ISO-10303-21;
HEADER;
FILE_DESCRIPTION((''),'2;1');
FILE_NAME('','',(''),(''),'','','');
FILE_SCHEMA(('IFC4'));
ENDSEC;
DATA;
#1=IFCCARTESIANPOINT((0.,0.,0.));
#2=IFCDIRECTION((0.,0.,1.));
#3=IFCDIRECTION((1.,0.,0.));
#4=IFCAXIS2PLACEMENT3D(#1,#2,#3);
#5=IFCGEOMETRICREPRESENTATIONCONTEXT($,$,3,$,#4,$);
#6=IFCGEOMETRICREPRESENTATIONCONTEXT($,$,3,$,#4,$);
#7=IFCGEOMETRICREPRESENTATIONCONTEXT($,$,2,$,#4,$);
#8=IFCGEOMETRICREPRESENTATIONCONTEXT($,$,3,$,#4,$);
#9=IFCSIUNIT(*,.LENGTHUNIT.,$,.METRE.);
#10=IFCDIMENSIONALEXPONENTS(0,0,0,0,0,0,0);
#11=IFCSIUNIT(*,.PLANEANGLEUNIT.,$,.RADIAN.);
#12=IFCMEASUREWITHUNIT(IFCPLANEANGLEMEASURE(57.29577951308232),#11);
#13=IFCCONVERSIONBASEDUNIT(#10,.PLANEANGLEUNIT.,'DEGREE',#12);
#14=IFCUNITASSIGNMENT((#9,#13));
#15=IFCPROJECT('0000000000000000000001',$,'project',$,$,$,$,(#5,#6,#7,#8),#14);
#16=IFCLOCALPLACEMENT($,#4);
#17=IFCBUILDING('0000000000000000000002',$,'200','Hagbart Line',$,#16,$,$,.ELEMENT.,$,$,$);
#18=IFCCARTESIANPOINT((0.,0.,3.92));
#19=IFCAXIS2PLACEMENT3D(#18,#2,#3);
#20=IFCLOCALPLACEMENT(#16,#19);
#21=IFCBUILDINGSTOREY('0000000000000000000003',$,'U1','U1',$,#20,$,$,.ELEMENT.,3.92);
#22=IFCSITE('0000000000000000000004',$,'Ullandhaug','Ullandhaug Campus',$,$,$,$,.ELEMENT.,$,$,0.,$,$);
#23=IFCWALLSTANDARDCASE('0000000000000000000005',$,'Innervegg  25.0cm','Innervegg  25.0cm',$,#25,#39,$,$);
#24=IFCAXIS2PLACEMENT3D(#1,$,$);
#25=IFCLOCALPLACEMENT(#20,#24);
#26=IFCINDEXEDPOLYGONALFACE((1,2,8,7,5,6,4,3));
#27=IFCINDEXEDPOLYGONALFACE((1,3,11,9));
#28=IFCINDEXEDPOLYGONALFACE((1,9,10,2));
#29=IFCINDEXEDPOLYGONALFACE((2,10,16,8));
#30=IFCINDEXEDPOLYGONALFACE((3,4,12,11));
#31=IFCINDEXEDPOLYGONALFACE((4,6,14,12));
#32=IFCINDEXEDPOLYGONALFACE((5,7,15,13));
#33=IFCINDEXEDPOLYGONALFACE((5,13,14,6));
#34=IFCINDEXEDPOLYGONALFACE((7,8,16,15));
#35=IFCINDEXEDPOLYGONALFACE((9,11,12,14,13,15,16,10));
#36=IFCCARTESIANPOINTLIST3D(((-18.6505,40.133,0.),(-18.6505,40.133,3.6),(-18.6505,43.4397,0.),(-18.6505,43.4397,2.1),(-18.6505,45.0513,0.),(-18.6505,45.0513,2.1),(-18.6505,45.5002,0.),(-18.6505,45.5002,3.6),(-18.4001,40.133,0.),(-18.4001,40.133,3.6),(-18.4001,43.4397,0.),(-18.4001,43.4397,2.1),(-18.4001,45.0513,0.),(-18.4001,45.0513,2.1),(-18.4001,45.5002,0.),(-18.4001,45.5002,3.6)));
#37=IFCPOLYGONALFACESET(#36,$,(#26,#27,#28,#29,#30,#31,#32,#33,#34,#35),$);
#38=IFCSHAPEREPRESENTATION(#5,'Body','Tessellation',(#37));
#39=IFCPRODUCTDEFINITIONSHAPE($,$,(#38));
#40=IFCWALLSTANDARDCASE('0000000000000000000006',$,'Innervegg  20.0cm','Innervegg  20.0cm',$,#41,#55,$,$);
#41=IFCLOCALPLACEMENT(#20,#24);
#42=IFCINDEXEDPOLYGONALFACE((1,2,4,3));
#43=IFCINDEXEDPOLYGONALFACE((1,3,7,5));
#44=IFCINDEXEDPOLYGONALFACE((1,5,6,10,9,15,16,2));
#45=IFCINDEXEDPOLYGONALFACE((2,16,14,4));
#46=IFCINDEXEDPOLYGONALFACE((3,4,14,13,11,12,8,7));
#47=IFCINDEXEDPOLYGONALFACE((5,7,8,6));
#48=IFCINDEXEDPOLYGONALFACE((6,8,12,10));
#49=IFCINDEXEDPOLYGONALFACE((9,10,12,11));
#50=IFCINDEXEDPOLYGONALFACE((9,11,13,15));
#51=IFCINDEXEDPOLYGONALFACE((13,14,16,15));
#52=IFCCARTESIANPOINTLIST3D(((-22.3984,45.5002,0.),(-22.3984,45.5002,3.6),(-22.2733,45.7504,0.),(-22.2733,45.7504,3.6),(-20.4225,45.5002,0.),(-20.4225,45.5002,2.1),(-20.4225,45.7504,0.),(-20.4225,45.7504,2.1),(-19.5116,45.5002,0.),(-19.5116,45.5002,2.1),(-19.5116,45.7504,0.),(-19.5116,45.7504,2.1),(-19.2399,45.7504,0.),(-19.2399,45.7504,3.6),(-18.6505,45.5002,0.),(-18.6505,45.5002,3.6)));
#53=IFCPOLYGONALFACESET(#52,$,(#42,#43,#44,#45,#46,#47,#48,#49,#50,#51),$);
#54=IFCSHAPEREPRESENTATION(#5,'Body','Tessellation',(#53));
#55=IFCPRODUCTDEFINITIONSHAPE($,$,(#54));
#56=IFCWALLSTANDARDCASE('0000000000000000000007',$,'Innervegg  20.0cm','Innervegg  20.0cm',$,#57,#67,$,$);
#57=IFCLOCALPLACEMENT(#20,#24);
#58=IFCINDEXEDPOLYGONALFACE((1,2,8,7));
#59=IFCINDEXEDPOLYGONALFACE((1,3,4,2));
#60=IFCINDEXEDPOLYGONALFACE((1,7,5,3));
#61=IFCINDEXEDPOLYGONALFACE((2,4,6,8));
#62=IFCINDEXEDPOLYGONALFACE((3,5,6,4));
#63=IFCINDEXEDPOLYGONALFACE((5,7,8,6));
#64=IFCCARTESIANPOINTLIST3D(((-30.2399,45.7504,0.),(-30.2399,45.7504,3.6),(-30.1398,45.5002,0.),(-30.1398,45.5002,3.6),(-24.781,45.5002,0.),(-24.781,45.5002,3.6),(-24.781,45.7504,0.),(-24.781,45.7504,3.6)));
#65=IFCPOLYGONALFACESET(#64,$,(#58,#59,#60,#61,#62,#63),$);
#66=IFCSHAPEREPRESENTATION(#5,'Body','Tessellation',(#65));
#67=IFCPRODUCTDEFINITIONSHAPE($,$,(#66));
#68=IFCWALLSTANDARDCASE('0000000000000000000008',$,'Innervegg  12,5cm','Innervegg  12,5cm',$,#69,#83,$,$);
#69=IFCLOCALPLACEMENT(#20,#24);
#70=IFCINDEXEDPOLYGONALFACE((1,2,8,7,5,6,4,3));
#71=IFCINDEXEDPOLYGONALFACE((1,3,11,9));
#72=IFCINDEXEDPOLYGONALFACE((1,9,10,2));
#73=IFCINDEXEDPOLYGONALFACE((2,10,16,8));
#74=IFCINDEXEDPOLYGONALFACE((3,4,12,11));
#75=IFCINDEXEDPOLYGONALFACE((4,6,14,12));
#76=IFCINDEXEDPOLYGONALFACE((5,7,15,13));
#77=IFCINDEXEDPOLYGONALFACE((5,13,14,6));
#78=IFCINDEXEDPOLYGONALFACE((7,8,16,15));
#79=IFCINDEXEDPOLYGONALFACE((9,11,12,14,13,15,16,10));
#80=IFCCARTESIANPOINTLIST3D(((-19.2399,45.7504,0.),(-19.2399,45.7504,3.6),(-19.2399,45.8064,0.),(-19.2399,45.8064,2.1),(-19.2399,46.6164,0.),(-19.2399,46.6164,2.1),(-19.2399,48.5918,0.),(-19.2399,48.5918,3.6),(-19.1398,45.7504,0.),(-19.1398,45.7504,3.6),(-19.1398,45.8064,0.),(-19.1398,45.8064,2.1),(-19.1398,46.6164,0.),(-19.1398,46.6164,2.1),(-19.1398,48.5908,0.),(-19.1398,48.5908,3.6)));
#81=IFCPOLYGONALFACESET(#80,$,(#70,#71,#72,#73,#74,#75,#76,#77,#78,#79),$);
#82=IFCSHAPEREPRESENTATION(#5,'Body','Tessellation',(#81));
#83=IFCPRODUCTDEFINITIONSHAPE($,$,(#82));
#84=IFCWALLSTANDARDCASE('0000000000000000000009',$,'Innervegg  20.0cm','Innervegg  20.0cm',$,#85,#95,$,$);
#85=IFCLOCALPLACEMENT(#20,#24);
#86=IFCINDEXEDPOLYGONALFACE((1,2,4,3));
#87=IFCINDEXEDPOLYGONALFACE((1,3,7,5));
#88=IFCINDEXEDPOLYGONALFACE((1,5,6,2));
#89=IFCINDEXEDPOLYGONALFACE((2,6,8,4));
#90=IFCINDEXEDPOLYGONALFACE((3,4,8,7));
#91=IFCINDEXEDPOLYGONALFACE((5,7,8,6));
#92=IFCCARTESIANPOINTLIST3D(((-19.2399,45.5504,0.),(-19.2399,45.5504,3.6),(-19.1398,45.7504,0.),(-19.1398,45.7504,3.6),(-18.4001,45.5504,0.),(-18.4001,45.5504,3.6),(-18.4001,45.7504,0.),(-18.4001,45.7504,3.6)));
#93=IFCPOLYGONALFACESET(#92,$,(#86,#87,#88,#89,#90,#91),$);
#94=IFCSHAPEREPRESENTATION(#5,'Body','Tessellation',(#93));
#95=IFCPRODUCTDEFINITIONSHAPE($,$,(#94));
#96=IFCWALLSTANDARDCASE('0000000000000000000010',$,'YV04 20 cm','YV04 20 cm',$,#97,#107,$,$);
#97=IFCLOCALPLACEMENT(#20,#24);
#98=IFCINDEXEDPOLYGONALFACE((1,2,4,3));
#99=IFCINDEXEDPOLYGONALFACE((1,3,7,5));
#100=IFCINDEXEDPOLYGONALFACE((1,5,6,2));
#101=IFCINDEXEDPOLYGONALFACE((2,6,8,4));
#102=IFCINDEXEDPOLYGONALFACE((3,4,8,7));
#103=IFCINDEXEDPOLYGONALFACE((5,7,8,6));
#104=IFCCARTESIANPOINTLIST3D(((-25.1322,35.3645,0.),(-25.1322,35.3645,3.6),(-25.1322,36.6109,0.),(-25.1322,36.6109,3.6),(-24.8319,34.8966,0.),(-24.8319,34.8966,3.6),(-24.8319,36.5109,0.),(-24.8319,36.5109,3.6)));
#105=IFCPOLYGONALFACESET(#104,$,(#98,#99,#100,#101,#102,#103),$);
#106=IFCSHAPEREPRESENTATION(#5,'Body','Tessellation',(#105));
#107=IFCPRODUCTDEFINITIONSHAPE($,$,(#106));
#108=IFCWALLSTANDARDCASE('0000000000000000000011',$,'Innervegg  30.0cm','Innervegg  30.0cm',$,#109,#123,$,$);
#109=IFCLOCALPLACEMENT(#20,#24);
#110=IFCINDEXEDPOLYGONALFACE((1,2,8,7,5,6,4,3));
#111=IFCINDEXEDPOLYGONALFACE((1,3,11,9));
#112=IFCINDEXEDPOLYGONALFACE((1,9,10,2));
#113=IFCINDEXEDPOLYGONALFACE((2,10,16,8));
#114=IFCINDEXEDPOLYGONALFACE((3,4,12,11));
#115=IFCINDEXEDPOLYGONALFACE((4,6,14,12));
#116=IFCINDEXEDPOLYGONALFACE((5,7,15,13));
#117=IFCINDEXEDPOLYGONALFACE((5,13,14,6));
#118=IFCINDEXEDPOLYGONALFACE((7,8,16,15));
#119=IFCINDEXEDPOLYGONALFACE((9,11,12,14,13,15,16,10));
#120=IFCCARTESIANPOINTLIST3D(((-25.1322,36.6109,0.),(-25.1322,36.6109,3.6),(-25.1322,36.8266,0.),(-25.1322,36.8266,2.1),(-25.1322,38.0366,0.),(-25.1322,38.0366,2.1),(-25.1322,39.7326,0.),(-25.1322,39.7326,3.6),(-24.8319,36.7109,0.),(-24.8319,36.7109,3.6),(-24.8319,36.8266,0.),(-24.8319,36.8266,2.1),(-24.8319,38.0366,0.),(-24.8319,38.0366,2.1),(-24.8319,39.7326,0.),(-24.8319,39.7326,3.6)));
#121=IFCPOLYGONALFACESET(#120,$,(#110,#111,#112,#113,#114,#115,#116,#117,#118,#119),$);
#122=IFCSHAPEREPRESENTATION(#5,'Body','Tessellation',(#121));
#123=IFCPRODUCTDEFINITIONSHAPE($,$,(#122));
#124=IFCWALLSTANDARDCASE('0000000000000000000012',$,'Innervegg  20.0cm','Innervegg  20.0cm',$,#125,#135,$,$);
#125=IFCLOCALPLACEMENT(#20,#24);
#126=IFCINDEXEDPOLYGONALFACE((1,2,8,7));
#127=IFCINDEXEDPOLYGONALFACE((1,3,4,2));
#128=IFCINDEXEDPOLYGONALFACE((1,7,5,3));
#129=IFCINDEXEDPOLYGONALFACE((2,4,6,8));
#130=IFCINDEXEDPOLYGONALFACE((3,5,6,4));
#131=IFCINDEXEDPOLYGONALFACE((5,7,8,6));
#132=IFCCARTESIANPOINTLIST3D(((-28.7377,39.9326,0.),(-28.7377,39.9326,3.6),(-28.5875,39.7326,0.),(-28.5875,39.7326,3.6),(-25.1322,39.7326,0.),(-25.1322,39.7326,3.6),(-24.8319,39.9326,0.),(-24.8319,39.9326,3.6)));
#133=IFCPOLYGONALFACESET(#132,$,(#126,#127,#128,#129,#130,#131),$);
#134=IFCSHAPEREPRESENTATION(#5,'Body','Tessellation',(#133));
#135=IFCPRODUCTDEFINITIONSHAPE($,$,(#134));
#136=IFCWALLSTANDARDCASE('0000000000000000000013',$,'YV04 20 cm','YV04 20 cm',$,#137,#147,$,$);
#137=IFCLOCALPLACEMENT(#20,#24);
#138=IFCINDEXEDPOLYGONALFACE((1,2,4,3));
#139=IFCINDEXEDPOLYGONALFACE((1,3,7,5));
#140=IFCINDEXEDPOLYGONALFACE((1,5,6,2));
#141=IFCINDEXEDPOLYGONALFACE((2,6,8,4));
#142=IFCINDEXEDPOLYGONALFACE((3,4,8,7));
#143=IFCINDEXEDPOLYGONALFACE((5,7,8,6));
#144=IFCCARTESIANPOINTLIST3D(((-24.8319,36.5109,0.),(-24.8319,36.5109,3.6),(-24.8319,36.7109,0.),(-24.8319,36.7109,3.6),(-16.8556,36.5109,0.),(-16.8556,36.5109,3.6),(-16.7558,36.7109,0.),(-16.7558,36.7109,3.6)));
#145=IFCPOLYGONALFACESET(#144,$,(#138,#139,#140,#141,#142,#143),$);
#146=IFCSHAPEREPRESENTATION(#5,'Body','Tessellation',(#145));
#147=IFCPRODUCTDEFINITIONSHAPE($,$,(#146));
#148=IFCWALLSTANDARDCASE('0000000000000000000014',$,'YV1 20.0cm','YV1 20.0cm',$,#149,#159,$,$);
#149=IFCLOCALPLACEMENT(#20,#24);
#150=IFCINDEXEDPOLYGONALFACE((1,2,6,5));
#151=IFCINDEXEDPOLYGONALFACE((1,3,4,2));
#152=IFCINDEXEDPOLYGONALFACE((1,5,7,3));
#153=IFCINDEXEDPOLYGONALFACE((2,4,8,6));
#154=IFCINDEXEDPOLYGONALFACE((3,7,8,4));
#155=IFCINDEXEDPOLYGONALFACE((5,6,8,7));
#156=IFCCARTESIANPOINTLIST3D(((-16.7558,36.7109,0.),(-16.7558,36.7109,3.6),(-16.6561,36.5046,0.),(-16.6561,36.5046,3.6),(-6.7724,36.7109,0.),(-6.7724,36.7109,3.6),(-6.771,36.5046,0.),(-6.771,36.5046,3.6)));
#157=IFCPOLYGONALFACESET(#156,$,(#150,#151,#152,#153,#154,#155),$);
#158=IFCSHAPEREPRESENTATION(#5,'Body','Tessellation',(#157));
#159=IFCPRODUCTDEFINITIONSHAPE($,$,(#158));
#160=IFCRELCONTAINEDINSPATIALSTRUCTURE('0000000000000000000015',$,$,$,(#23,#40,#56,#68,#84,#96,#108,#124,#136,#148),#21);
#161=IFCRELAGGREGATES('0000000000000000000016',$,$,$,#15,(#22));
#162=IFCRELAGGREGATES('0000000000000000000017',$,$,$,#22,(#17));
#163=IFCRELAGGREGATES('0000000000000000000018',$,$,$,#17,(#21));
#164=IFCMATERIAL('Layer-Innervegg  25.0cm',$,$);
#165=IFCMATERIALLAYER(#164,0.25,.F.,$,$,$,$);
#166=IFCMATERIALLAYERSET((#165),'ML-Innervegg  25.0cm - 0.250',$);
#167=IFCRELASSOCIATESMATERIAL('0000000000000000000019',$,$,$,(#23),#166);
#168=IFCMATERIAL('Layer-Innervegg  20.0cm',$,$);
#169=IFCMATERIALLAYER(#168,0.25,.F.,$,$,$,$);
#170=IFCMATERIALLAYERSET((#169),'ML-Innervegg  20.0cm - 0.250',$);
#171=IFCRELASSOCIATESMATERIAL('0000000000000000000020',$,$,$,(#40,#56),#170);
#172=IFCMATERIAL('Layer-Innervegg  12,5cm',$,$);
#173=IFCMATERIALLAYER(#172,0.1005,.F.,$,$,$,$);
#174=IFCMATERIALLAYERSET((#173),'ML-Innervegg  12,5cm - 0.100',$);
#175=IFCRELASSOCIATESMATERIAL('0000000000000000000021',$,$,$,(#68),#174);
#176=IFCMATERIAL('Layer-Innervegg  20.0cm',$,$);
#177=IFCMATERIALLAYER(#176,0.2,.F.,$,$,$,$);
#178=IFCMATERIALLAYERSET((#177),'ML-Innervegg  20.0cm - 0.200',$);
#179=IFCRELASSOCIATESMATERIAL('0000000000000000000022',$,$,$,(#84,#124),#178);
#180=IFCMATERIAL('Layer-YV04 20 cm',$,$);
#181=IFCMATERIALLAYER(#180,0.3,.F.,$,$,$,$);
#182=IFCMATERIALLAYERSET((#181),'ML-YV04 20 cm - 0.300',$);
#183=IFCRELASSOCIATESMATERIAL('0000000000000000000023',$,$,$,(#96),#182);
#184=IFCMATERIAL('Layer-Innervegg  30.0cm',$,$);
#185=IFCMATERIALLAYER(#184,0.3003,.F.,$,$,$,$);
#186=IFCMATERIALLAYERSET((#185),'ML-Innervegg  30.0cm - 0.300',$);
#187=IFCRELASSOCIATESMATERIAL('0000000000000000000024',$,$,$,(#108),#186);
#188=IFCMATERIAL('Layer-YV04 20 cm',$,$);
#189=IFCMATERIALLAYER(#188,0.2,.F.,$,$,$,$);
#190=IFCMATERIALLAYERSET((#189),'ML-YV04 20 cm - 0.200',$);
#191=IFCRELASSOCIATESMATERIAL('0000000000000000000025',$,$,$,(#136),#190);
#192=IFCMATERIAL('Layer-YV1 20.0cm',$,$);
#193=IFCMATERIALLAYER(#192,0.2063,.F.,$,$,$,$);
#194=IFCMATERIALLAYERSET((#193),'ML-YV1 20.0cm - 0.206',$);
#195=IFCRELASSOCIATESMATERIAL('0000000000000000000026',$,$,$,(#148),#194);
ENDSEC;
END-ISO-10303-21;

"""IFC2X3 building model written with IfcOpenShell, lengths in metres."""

from ifc_helpers import new_model, entity, si_unit, converted_unit, frame, origin_with_axes, place, context, project, spatial, polyline, outline, extrude, material, layer, layer_set, layer_usage, element, save


model = new_model("IFC2X3")

# Units and contexts
context_of_model_1 = context(None, 3, world=origin_with_axes())
context_of_model_2 = context(None, 3, world=origin_with_axes())
context_of_model_3 = context(None, 2, world=origin_with_axes())
context_of_model_4 = context(None, 3, world=origin_with_axes())
ifc_project = project(units=[si_unit("LENGTHUNIT", "METRE"), converted_unit("PLANEANGLEUNIT", "DEGREE", entity("IfcPlaneAngleMeasure", 57.29577951308232), si_unit("PLANEANGLEUNIT", "RADIAN"), dimensions=[0, 0, 0, 0, 0, 0, 0])], contexts=[context_of_model_1, context_of_model_2, context_of_model_3, context_of_model_4])

# Site, building, storey
site = spatial("IfcSite", under=ifc_project, Name="Ullandhaug", Description="Ullandhaug Campus", CompositionType="ELEMENT", RefElevation=0.0)
building_placement = place(None, origin_with_axes())
building = spatial("IfcBuilding", under=site, at=building_placement, Name="200", Description="Hagbart Line", CompositionType="ELEMENT")
storey_placement = place(building_placement, frame((0.0, 0.0, 3.92), z_axis=(0.0, 0.0, 1.0), x_axis=(1.0, 0.0, 0.0)))
storey = spatial("IfcBuildingStorey", under=building, at=storey_placement, Name="U1", Description="U1", CompositionType="ELEMENT", Elevation=3.92)

# Shared definitions
ifc_material_1 = material(Name="Layer-Innervegg  20.0cm")
ifc_layer_1 = layer(ifc_material_1, 0.25, ventilated=False)
ifc_layer_set_1 = layer_set([ifc_layer_1], Name="ML-Innervegg  20.0cm - 0.250")
ifc_layer_usage_1 = layer_usage(ifc_layer_set_1, "AXIS2", "POSITIVE", 0.0)

# Shared definitions
ifc_material_2 = material(Name="Layer-Innervegg  20.0cm")
ifc_layer_2 = layer(ifc_material_2, 0.2, ventilated=False)
ifc_layer_set_2 = layer_set([ifc_layer_2], Name="ML-Innervegg  20.0cm - 0.200")
ifc_layer_usage_2 = layer_usage(ifc_layer_set_2, "AXIS2", "POSITIVE", 0.0)

# Walls, openings
ifc_material_3 = material(Name="Layer-Innervegg  25.0cm")
ifc_layer_3 = layer(ifc_material_3, 0.25, ventilated=False)
ifc_layer_set_3 = layer_set([ifc_layer_3], Name="ML-Innervegg  25.0cm - 0.250")
ifc_layer_usage_3 = layer_usage(ifc_layer_set_3, "AXIS2", "POSITIVE", 0.0)
wall_1_placement = place(storey_placement, frame((-18.6505, 45.5002, 0.0), z_axis=(0.0, 0.0, 1.0), x_axis=(0.0, -1.0, 0.0)))
wall_1 = element("IfcWallStandardCase", 1, at=wall_1_placement, inside=storey, material=ifc_layer_usage_3, Name="Innervegg  25.0cm", Description="Innervegg  25.0cm", context=context_of_model_1, shape_type="SweptSolid", body=[
    extrude(outline(polyline([(0.0, 0.0), (5.3672, 0.0), (5.3672, 0.2505), (0.0, 0.2505), (0.0, 0.0)])), frame((0.0, 0.0, 0.0), z_axis=(0.0, 0.0, 1.0), x_axis=(1.0, 0.0, 0.0)), (0.0, 0.0, 1.0), 3.6),
])
opening_1_placement = place(wall_1_placement, frame((0.4488, 0.2505, 0.0), z_axis=(0.0, 0.0, 1.0), x_axis=(1.0, 0.0, 0.0)))
element("IfcOpeningElement", 2, at=opening_1_placement, cuts=wall_1, context=context_of_model_1, shape_type="SweptSolid", body=[
    extrude(outline(polyline([(0.0, 0.0), (2.1, 0.0), (2.1, 1.6116), (0.0, 1.6116), (0.0, 0.0)])), frame((0.0, 0.0, 0.0), z_axis=(0.0, 1.0, 0.0), x_axis=(0.0, 0.0, 1.0)), (0.0, 0.0, -1.0), 0.2505),
])
wall_2_placement = place(storey_placement, frame((-19.2399, 45.7504, 0.0), z_axis=(0.0, 0.0, 1.0), x_axis=(-1.0, 0.0, 0.0)))
wall_2 = element("IfcWallStandardCase", 3, at=wall_2_placement, inside=storey, material=ifc_layer_usage_1, Name="Innervegg  20.0cm", Description="Innervegg  20.0cm", context=context_of_model_1, shape_type="SweptSolid", body=[
    extrude(outline(polyline([(0.0, 0.0), (3.0334, 0.0), (3.1585, 0.2502), (-0.5894, 0.2502), (0.0, 0.0)])), frame((0.0, 0.0, 0.0), z_axis=(0.0, 0.0, 1.0), x_axis=(1.0, 0.0, 0.0)), (0.0, 0.0, 1.0), 3.6),
])
opening_2_placement = place(wall_2_placement, frame((0.2717, 0.2502, 0.0), z_axis=(0.0, 0.0, 1.0), x_axis=(1.0, 0.0, 0.0)))
element("IfcOpeningElement", 4, at=opening_2_placement, cuts=wall_2, context=context_of_model_1, shape_type="SweptSolid", body=[
    extrude(outline(polyline([(0.0, 0.0), (2.1, 0.0), (2.1, 0.9109), (0.0, 0.9109), (0.0, 0.0)])), frame((0.0, 0.0, 0.0), z_axis=(0.0, 1.0, 0.0), x_axis=(0.0, 0.0, 1.0)), (0.0, 0.0, -1.0), 0.2502),
])

# Wall
wall_3_placement = place(storey_placement, frame((-24.781, 45.7504, 0.0), z_axis=(0.0, 0.0, 1.0), x_axis=(-1.0, 0.0, 0.0)))
element("IfcWallStandardCase", 5, at=wall_3_placement, inside=storey, material=ifc_layer_usage_1, Name="Innervegg  20.0cm", Description="Innervegg  20.0cm", context=context_of_model_1, shape_type="SweptSolid", body=[
    extrude(outline(polyline([(0.0, 0.0), (5.4589, 0.0), (5.3588, 0.2502), (0.0, 0.2502), (0.0, 0.0)])), frame((0.0, 0.0, 0.0), z_axis=(0.0, 0.0, 1.0), x_axis=(1.0, 0.0, 0.0)), (0.0, 0.0, 1.0), 3.6),
])

# Wall, opening
ifc_material_4 = material(Name="Layer-Innervegg  12,5cm")
ifc_layer_4 = layer(ifc_material_4, 0.1005, ventilated=False)
ifc_layer_set_4 = layer_set([ifc_layer_4], Name="ML-Innervegg  12,5cm - 0.100")
ifc_layer_usage_4 = layer_usage(ifc_layer_set_4, "AXIS2", "POSITIVE", 0.0)
wall_4_placement = place(storey_placement, frame((-19.1398, 45.7504, 0.0), z_axis=(0.0, 0.0, 1.0), x_axis=(0.0, 1.0, 0.0)))
wall_4 = element("IfcWallStandardCase", 6, at=wall_4_placement, inside=storey, material=ifc_layer_usage_4, Name="Innervegg  12,5cm", Description="Innervegg  12,5cm", context=context_of_model_1, shape_type="SweptSolid", body=[
    extrude(outline(polyline([(0.0, 0.0), (2.8404, 0.0), (2.8414, 0.1001), (0.0, 0.1001), (0.0, 0.0)])), frame((0.0, 0.0, 0.0), z_axis=(0.0, 0.0, 1.0), x_axis=(1.0, 0.0, 0.0)), (0.0, 0.0, 1.0), 3.6),
])
opening_3_placement = place(wall_4_placement, frame((0.056, 0.1001, 0.0), z_axis=(0.0, 0.0, 1.0), x_axis=(1.0, 0.0, 0.0)))
element("IfcOpeningElement", 7, at=opening_3_placement, cuts=wall_4, context=context_of_model_1, shape_type="SweptSolid", body=[
    extrude(outline(polyline([(0.0, 0.0), (2.1, 0.0), (2.1, 0.81), (0.0, 0.81), (0.0, 0.0)])), frame((0.0, 0.0, 0.0), z_axis=(0.0, 1.0, 0.0), x_axis=(0.0, 0.0, 1.0)), (0.0, 0.0, -1.0), 0.1001),
])

# Walls
wall_5_placement = place(storey_placement, frame((-19.2399, 45.5504, 0.0), z_axis=(0.0, 0.0, 1.0), x_axis=(1.0, 0.0, 0.0)))
element("IfcWallStandardCase", 8, at=wall_5_placement, inside=storey, material=ifc_layer_usage_2, Name="Innervegg  20.0cm", Description="Innervegg  20.0cm", context=context_of_model_1, shape_type="SweptSolid", body=[
    extrude(outline(polyline([(0.0, 0.0), (0.8398, 0.0), (0.8398, 0.2), (0.1001, 0.2), (0.0, 0.0)])), origin_with_axes(), (0.0, 0.0, 1.0), 3.6),
])
ifc_material_5 = material(Name="Layer-YV04 20 cm")
ifc_layer_5 = layer(ifc_material_5, 0.3, ventilated=False)
ifc_layer_set_5 = layer_set([ifc_layer_5], Name="ML-YV04 20 cm - 0.300")
ifc_layer_usage_5 = layer_usage(ifc_layer_set_5, "AXIS2", "POSITIVE", 0.0)
wall_6_placement = place(storey_placement, frame((-24.8319, 34.8966, 0.0), z_axis=(0.0, 0.0, 1.0), x_axis=(0.0, 1.0, 0.0)))
element("IfcWallStandardCase", 9, at=wall_6_placement, inside=storey, material=ifc_layer_usage_5, Name="YV04 20 cm", Description="YV04 20 cm", context=context_of_model_1, shape_type="SweptSolid", body=[
    extrude(outline(polyline([(0.0, 0.0), (1.6143, 0.0), (1.7143, 0.3003), (0.4679, 0.3003), (0.0, 0.0)])), frame((0.0, 0.0, 0.0), z_axis=(0.0, 0.0, 1.0), x_axis=(1.0, 0.0, 0.0)), (0.0, 0.0, 1.0), 3.6),
])

# Wall, opening
ifc_material_6 = material(Name="Layer-Innervegg  30.0cm")
ifc_layer_6 = layer(ifc_material_6, 0.3003, ventilated=False)
ifc_layer_set_6 = layer_set([ifc_layer_6], Name="ML-Innervegg  30.0cm - 0.300")
ifc_layer_usage_6 = layer_usage(ifc_layer_set_6, "AXIS2", "POSITIVE", 0.0)
wall_7_placement = place(storey_placement, frame((-24.8319, 36.7109, 0.0), z_axis=(0.0, 0.0, 1.0), x_axis=(0.0, 1.0, 0.0)))
wall_7 = element("IfcWallStandardCase", 10, at=wall_7_placement, inside=storey, material=ifc_layer_usage_6, Name="Innervegg  30.0cm", Description="Innervegg  30.0cm", context=context_of_model_1, shape_type="SweptSolid", body=[
    extrude(outline(polyline([(0.0, 0.0), (3.0216, 0.0), (3.0216, 0.3003), (-0.1, 0.3003), (0.0, 0.0)])), frame((0.0, 0.0, 0.0), z_axis=(0.0, 0.0, 1.0), x_axis=(1.0, 0.0, 0.0)), (0.0, 0.0, 1.0), 3.6),
])
opening_4_placement = place(wall_7_placement, frame((0.1156, 0.3003, 0.0), z_axis=(0.0, 0.0, 1.0), x_axis=(1.0, 0.0, 0.0)))
element("IfcOpeningElement", 11, at=opening_4_placement, cuts=wall_7, context=context_of_model_1, shape_type="SweptSolid", body=[
    extrude(outline(polyline([(0.0, 0.0), (2.1, 0.0), (2.1, 1.21), (0.0, 1.21), (0.0, 0.0)])), frame((0.0, 0.0, 0.0), z_axis=(0.0, 1.0, 0.0), x_axis=(0.0, 0.0, 1.0)), (0.0, 0.0, -1.0), 0.3003),
])

# Walls
wall_8_placement = place(storey_placement, frame((-24.8319, 39.9326, 0.0), z_axis=(0.0, 0.0, 1.0), x_axis=(-1.0, 0.0, 0.0)))
element("IfcWallStandardCase", 12, at=wall_8_placement, inside=storey, material=ifc_layer_usage_2, Name="Innervegg  20.0cm", Description="Innervegg  20.0cm", context=context_of_model_1, shape_type="SweptSolid", body=[
    extrude(outline(polyline([(0.0, 0.0), (3.9058, 0.0), (3.7556, 0.2), (0.3003, 0.2), (0.0, 0.0)])), frame((0.0, 0.0, 0.0), z_axis=(0.0, 0.0, 1.0), x_axis=(1.0, 0.0, 0.0)), (0.0, 0.0, 1.0), 3.6),
])
ifc_material_7 = material(Name="Layer-YV04 20 cm")
ifc_layer_7 = layer(ifc_material_7, 0.2, ventilated=False)
ifc_layer_set_7 = layer_set([ifc_layer_7], Name="ML-YV04 20 cm - 0.200")
ifc_layer_usage_7 = layer_usage(ifc_layer_set_7, "AXIS2", "POSITIVE", 0.0)
wall_9_placement = place(storey_placement, frame((-24.8319, 36.5109, 0.0), z_axis=(0.0, 0.0, 1.0), x_axis=(1.0, 0.0, 0.0)))
element("IfcWallStandardCase", 13, at=wall_9_placement, inside=storey, material=ifc_layer_usage_7, Name="YV04 20 cm", Description="YV04 20 cm", context=context_of_model_1, shape_type="SweptSolid", body=[
    extrude(outline(polyline([(0.0, 0.0), (7.9763, 0.0), (8.0761, 0.2), (0.0, 0.2), (0.0, 0.0)])), origin_with_axes(), (0.0, 0.0, 1.0), 3.6),
])
ifc_material_8 = material(Name="Layer-YV1 20.0cm")
ifc_layer_8 = layer(ifc_material_8, 0.2063, ventilated=False)
ifc_layer_set_8 = layer_set([ifc_layer_8], Name="ML-YV1 20.0cm - 0.206")
ifc_layer_usage_8 = layer_usage(ifc_layer_set_8, "AXIS2", "POSITIVE", 0.0)
wall_10_placement = place(storey_placement, frame((-16.6561, 36.5046, 0.0), z_axis=(0.0, 0.0, 1.0), x_axis=(1.0, 0.0, 0.0)))
element("IfcWallStandardCase", 14, at=wall_10_placement, inside=storey, material=ifc_layer_usage_8, Name="YV1 20.0cm", Description="YV1 20.0cm", context=context_of_model_1, shape_type="SweptSolid", body=[
    extrude(outline(polyline([(0.0, 0.0), (9.8851, 0.0), (9.8837, 0.2063), (-0.0998, 0.2063), (0.0, 0.0)])), origin_with_axes(), (0.0, 0.0, 1.0), 3.6),
])

save(model, "model.ifc")
